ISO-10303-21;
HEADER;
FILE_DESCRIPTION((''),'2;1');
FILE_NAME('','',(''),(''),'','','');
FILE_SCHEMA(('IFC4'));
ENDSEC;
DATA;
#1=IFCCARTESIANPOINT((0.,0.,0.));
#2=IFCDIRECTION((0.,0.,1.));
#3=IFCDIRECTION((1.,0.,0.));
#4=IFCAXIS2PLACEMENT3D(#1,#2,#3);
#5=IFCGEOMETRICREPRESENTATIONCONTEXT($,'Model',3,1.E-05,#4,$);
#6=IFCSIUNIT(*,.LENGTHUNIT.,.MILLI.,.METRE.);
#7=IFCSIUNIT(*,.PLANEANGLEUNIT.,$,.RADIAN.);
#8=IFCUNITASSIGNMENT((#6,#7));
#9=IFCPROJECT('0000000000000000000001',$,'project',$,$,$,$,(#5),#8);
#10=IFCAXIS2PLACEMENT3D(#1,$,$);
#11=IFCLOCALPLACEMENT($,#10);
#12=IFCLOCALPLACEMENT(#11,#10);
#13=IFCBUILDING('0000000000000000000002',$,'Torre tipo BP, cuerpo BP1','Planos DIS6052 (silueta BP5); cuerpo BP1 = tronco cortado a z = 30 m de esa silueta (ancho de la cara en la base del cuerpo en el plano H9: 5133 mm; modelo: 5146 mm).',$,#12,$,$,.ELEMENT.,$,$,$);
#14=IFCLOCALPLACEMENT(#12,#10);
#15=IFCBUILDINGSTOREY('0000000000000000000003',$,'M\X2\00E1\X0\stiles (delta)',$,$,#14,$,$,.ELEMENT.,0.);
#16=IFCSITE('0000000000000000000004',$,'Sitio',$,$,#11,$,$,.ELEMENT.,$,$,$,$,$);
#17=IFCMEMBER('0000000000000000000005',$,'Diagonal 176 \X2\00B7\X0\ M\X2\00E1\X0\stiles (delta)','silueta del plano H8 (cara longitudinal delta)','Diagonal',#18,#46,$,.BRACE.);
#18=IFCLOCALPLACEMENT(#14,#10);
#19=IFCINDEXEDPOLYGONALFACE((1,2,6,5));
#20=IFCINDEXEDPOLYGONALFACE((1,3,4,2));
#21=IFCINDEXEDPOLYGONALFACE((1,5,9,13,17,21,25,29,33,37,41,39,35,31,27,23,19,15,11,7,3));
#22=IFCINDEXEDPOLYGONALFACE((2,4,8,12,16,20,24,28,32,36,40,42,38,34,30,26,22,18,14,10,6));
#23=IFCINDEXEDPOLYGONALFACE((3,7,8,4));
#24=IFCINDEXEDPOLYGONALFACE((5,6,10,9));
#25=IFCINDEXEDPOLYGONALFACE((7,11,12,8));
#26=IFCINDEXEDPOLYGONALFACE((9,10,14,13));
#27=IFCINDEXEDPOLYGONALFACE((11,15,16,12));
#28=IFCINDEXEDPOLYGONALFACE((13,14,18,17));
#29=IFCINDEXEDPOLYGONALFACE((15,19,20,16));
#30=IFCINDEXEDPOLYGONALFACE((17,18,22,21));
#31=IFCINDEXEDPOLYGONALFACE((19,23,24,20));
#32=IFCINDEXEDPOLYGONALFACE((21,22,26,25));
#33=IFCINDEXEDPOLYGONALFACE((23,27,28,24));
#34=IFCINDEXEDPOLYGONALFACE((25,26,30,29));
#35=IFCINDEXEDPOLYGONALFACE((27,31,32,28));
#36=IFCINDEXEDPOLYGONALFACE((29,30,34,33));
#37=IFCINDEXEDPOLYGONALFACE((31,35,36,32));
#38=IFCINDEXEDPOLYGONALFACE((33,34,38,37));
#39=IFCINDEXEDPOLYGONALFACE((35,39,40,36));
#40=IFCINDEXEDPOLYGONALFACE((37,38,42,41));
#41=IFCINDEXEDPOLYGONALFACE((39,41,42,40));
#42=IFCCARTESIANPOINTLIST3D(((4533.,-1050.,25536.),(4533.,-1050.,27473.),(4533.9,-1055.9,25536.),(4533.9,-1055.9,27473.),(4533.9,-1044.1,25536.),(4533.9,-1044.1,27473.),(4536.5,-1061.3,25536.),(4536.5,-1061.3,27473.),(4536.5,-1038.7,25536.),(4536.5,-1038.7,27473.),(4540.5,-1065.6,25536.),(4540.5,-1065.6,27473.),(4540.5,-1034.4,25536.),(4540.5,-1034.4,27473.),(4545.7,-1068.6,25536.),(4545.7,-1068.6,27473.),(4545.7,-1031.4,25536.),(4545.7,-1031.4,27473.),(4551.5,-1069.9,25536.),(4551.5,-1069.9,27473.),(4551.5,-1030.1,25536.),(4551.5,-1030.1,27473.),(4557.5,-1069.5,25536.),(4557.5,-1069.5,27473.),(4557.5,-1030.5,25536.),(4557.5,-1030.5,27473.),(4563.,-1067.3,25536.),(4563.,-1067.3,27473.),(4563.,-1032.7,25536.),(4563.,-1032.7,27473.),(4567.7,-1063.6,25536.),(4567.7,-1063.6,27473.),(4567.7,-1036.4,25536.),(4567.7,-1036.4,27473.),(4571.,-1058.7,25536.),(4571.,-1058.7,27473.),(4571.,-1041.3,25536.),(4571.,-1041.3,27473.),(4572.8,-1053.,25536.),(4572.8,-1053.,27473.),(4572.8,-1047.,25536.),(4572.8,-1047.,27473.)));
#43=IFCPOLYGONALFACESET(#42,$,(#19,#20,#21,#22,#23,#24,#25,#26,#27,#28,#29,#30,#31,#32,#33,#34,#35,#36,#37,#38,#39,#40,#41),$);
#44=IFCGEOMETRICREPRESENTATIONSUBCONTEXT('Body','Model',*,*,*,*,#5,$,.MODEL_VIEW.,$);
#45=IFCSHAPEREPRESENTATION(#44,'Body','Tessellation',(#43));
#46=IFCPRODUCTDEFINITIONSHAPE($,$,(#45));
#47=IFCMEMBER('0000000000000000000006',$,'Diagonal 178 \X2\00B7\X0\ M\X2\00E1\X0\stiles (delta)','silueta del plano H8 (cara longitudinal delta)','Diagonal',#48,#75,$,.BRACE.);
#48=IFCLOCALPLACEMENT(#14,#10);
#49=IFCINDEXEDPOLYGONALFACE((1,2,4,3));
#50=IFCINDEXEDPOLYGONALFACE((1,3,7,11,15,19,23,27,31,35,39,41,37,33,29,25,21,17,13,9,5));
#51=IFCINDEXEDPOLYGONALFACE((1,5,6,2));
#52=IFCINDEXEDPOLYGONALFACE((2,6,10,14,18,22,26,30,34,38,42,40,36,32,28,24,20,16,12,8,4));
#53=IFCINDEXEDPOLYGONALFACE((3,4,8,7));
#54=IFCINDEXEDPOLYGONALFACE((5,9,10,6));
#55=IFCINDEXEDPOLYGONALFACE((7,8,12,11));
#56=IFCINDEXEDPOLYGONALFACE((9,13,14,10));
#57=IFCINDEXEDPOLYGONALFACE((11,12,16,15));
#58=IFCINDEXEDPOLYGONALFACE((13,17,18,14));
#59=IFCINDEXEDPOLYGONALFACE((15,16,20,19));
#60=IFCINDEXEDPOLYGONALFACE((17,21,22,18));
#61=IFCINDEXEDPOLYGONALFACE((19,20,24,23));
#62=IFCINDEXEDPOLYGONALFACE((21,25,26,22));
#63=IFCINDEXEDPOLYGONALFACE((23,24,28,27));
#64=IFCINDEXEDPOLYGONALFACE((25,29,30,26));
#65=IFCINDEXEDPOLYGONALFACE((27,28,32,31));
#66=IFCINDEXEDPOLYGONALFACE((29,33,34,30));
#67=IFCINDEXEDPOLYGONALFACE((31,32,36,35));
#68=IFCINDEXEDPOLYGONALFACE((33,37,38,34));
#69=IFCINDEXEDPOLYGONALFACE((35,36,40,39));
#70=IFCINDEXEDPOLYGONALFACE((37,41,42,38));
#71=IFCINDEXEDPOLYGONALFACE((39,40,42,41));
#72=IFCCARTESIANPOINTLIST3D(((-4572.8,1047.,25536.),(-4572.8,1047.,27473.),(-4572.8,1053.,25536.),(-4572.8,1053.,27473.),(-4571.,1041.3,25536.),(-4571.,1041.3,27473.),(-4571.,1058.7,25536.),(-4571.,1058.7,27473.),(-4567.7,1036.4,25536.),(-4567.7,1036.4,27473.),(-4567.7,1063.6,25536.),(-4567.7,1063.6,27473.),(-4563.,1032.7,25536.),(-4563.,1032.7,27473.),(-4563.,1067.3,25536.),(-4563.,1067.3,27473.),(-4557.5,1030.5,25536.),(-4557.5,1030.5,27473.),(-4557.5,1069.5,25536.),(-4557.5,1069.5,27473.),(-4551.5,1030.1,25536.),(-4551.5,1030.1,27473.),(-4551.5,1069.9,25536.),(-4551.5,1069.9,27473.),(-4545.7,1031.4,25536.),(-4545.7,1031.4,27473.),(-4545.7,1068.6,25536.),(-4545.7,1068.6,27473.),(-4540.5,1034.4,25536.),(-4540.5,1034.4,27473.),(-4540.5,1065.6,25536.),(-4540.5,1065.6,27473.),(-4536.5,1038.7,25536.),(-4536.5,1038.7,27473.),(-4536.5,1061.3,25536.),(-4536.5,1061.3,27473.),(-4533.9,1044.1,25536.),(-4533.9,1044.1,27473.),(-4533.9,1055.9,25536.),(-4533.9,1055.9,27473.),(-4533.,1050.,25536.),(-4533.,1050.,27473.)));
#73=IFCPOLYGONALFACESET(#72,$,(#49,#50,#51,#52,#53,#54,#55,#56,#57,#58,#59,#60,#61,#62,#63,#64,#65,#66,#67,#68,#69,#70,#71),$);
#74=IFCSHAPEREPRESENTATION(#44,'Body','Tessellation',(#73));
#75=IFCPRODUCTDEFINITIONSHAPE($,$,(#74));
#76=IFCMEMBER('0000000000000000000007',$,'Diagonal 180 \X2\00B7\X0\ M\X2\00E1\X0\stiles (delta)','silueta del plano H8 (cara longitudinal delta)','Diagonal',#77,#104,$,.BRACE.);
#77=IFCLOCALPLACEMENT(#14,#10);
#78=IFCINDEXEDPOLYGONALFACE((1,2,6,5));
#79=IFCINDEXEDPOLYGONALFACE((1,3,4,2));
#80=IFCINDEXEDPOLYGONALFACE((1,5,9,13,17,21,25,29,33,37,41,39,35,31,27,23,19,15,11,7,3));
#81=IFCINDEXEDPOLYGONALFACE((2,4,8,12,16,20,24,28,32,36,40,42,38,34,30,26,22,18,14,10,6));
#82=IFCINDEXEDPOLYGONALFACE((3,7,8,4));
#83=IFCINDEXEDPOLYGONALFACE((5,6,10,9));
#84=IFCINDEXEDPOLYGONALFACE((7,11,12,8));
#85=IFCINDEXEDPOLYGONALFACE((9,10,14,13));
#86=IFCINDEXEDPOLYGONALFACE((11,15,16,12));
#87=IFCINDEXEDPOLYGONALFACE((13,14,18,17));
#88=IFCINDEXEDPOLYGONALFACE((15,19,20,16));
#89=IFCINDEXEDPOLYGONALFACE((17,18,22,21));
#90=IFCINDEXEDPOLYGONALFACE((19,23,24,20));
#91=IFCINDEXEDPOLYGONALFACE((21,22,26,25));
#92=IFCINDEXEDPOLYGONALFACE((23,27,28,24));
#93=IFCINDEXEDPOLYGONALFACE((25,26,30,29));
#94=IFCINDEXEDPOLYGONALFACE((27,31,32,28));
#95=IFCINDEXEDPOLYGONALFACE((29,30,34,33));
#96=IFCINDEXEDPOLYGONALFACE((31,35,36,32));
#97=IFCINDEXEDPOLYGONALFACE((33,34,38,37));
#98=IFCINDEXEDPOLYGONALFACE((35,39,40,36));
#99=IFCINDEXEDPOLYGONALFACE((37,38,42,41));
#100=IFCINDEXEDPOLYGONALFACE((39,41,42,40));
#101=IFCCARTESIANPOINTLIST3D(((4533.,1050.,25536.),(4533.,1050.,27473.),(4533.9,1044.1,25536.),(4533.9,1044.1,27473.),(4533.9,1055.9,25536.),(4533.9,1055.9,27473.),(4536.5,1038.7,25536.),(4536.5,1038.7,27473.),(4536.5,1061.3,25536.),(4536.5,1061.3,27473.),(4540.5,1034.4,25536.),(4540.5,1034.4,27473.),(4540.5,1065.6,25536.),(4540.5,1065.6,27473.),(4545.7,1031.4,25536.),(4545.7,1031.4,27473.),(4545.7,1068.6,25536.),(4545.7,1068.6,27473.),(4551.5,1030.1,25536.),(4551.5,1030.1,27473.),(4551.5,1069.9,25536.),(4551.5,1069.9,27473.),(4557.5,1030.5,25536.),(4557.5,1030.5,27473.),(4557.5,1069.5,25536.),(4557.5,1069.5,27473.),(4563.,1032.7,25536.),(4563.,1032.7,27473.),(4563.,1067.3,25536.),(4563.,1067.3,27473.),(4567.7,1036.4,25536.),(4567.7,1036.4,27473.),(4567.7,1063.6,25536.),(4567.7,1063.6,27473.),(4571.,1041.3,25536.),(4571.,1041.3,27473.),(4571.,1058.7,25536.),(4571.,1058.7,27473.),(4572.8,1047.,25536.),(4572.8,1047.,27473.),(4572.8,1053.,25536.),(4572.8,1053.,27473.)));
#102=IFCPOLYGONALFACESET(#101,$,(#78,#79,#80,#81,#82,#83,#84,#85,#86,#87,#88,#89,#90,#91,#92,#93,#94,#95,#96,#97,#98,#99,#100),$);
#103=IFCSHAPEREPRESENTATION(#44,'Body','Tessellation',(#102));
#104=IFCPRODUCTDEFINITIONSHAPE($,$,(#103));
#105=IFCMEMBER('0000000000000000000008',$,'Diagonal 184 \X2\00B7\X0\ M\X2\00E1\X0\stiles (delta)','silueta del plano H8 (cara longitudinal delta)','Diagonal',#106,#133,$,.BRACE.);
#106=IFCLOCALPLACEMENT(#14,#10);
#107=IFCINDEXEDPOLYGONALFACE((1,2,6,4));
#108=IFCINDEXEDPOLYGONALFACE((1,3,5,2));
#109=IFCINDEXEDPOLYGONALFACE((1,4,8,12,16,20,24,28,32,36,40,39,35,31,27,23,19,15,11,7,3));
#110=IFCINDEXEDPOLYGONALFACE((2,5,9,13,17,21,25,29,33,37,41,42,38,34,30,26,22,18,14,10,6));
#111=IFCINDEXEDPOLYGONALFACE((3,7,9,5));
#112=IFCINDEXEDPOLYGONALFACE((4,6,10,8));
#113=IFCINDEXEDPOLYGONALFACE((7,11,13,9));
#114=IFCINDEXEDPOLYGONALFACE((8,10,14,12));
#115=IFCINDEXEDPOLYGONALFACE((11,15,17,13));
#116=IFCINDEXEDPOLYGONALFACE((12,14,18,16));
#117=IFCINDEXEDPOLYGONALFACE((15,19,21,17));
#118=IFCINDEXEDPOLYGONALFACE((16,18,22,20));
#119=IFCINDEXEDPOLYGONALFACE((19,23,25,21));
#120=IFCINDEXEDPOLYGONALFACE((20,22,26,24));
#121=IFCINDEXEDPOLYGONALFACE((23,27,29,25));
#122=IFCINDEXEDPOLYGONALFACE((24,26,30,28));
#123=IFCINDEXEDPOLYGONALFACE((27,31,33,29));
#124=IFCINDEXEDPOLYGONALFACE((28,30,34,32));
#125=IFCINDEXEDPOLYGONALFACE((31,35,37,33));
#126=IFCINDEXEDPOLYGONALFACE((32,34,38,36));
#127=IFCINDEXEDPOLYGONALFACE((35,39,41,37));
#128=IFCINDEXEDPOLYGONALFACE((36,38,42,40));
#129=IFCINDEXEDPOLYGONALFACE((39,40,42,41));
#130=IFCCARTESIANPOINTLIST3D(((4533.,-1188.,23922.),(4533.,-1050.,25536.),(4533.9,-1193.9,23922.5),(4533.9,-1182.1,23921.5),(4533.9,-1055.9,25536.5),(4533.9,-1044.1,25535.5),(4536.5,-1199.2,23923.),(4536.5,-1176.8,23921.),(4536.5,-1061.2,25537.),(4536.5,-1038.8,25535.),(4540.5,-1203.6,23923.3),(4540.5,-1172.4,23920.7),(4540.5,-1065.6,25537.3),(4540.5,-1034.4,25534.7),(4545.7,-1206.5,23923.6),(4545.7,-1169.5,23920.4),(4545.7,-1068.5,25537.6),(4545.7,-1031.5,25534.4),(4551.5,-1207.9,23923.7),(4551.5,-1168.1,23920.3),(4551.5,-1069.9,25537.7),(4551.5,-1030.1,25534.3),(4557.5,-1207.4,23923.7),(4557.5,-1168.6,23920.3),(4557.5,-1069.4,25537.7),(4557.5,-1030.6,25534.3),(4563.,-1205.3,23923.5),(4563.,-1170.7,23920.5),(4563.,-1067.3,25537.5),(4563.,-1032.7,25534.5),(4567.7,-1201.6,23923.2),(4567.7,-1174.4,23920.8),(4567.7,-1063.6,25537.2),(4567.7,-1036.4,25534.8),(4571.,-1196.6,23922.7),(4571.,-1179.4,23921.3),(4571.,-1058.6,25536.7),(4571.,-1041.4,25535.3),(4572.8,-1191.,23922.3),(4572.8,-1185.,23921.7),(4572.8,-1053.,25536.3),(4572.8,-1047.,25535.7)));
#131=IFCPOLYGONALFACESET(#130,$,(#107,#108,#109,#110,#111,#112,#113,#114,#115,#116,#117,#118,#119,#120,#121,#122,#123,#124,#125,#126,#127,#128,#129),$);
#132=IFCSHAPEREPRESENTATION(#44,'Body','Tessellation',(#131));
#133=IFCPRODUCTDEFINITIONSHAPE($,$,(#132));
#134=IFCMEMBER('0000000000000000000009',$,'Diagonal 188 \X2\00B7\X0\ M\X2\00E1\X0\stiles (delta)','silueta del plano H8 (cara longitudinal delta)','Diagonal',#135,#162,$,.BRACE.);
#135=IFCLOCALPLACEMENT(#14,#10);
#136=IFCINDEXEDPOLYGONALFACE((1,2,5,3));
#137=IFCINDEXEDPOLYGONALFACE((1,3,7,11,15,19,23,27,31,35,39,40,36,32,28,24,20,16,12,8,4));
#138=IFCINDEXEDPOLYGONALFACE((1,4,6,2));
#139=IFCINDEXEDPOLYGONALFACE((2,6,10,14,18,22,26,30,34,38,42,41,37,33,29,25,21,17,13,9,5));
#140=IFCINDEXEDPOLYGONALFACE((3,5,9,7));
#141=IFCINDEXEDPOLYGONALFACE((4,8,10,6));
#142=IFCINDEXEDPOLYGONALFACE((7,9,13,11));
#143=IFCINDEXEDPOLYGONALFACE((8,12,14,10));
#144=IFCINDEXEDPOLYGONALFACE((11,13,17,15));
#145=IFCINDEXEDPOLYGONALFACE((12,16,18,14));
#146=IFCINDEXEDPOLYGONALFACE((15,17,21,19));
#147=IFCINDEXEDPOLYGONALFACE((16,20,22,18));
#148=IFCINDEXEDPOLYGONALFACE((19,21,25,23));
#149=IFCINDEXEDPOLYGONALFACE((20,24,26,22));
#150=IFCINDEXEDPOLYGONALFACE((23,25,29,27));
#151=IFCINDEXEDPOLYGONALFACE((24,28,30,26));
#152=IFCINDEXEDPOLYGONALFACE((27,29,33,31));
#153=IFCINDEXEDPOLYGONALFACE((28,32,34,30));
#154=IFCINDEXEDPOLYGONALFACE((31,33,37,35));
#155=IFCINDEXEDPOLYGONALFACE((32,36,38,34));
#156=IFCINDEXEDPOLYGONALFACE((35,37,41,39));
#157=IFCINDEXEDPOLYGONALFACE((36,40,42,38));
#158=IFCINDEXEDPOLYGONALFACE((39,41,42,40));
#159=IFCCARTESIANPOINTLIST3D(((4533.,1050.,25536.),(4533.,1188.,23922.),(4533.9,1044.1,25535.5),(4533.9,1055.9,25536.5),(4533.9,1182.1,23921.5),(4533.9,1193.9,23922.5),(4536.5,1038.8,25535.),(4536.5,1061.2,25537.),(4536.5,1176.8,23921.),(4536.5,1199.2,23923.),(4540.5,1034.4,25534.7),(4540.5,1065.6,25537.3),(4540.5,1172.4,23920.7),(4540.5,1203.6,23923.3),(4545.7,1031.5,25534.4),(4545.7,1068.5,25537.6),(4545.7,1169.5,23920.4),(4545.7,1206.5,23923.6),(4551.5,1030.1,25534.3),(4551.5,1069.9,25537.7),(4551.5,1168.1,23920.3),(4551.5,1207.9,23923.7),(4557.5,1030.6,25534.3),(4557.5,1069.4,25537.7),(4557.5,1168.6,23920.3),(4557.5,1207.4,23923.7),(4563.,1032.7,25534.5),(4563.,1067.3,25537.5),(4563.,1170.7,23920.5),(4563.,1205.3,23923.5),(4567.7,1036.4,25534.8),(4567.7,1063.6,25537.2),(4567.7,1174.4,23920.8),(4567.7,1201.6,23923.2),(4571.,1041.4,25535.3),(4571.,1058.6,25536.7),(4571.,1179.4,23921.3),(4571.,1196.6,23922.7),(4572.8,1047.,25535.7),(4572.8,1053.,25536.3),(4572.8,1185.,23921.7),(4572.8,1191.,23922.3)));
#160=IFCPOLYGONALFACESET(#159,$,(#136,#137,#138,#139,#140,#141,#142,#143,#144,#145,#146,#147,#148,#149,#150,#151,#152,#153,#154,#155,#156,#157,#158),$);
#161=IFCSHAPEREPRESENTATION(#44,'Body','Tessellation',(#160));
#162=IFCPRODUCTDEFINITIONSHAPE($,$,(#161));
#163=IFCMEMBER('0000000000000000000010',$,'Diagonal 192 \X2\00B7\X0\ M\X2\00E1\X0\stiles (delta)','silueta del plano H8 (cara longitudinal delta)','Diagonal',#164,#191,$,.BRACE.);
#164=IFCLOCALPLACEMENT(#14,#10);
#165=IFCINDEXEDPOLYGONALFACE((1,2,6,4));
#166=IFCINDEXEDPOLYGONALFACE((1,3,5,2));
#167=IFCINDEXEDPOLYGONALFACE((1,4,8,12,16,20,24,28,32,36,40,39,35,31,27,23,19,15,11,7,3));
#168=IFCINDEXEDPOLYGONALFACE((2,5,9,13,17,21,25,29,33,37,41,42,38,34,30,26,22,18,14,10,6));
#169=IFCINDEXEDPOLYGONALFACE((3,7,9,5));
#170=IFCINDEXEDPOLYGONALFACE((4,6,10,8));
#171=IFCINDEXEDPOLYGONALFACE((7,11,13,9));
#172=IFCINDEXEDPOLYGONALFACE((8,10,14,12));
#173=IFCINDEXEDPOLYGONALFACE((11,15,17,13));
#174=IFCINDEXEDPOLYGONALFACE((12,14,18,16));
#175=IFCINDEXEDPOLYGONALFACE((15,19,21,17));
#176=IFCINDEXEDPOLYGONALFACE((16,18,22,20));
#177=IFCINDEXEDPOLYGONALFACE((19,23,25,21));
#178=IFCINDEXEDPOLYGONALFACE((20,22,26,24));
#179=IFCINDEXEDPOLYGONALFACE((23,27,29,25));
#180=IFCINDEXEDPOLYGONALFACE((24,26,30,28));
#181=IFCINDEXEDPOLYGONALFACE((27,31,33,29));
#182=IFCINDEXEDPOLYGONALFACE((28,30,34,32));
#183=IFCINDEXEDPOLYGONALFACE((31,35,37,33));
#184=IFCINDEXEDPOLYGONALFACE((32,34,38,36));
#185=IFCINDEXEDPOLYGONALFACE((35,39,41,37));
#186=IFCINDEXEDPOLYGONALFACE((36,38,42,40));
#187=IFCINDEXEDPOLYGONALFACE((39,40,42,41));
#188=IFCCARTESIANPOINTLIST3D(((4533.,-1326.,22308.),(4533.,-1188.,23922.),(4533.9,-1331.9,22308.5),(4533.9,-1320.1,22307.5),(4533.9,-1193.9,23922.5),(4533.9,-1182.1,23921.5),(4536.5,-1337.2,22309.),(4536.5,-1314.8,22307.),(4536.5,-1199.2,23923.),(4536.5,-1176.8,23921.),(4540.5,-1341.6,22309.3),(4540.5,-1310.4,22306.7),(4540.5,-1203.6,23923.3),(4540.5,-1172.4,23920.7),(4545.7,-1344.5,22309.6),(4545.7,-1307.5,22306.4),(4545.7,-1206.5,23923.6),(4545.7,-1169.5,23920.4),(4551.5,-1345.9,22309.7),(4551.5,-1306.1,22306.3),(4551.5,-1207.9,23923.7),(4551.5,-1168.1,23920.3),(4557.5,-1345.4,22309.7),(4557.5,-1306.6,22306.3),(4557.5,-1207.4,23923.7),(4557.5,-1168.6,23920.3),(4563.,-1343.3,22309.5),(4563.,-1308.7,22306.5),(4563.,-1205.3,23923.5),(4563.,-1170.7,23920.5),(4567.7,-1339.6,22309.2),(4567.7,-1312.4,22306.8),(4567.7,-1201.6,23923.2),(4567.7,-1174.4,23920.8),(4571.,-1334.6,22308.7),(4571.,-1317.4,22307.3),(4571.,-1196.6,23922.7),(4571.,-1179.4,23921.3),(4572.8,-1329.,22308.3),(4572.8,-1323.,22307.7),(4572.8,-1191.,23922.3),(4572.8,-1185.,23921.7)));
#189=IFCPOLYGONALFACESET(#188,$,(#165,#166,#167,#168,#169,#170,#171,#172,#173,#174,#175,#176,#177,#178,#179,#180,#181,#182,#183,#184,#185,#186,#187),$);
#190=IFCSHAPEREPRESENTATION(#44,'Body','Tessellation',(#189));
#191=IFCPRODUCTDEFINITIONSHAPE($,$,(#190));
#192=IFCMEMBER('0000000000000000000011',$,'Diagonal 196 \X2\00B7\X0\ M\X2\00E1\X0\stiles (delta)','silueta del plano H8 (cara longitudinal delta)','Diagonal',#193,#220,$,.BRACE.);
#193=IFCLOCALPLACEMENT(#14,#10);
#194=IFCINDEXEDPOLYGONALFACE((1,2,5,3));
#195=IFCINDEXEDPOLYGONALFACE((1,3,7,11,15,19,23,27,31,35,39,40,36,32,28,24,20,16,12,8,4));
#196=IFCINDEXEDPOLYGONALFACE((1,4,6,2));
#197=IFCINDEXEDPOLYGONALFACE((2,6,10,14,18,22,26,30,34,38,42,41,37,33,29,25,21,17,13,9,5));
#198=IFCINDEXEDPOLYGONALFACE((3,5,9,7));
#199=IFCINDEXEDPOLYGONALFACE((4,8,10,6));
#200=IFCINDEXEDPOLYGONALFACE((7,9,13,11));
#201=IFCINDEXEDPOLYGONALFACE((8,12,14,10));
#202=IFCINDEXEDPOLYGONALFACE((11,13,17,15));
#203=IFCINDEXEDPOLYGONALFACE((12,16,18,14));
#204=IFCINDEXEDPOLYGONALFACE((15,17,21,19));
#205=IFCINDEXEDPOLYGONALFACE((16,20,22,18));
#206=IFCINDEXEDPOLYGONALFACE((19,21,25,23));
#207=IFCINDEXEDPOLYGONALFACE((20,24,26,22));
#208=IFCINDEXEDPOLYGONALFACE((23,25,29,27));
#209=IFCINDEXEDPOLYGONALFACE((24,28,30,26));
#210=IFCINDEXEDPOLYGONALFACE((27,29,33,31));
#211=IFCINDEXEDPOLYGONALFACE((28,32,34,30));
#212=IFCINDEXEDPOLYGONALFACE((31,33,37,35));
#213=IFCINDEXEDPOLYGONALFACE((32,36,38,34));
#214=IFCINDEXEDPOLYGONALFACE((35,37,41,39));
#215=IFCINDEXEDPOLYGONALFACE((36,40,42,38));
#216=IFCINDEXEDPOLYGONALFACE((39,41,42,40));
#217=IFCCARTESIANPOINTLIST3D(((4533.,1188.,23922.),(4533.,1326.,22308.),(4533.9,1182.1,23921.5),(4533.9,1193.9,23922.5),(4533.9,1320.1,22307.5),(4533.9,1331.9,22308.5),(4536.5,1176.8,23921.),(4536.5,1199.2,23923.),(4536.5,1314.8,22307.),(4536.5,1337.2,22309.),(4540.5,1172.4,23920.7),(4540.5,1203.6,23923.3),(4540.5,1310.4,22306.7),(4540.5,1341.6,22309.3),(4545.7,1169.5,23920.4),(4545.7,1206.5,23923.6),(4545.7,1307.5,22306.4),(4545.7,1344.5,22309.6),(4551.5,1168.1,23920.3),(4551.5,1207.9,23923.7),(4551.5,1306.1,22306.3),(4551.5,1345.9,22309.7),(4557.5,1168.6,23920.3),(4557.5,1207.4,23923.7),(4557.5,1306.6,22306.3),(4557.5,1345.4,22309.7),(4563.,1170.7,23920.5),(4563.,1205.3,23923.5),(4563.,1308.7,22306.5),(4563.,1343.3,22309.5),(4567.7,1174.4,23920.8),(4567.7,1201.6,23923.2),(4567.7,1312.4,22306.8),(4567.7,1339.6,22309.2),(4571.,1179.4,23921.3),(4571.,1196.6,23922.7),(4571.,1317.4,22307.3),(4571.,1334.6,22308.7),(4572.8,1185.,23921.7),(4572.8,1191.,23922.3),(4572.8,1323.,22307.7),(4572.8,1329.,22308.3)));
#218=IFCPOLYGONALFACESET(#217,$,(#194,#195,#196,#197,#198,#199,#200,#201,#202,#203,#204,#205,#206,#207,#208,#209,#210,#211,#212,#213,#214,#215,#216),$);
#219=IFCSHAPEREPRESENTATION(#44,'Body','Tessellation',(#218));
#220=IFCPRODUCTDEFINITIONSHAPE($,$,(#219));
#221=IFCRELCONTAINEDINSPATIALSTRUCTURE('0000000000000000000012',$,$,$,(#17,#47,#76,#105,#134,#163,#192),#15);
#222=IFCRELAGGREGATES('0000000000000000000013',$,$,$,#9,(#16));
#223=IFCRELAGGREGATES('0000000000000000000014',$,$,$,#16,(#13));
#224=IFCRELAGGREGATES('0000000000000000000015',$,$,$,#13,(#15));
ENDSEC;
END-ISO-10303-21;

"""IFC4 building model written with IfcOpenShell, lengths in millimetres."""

from ifc_helpers import new_model, si_unit, frame, origin, origin_with_axes, place, context, subcontext, project, spatial, circle, extrude, element, save


model = new_model("IFC4")

# Units and contexts
model_context = context("Model", 3, precision=1e-05, world=origin_with_axes())
body_context = subcontext(model_context, "Body", "Model", "MODEL_VIEW")
ifc_project = project(units=[si_unit("LENGTHUNIT", "METRE", prefix="MILLI"), si_unit("PLANEANGLEUNIT", "RADIAN")], contexts=[model_context])

# Site, building, storey
site_placement = place(None, origin())
site = spatial("IfcSite", under=ifc_project, at=site_placement, Name="Sitio", CompositionType="ELEMENT")
building_placement = place(site_placement, origin())
building = spatial("IfcBuilding", under=site, at=building_placement, Name="Torre tipo BP, cuerpo BP1", Description="Planos DIS6052 (silueta BP5); cuerpo BP1 = tronco cortado a z = 30 m de esa silueta (ancho de la cara en la base del cuerpo en el plano H9: 5133 mm; modelo: 5146 mm).", CompositionType="ELEMENT")
storey_placement = place(building_placement, origin())
storey = spatial("IfcBuildingStorey", under=building, at=storey_placement, Name="Mástiles (delta)", CompositionType="ELEMENT", Elevation=0.0)

# Members
for number, where, z_axis, x_axis, name in (
    (1, (4553.0, -1050.0, 27473.0), (0.0, 0.0, -1.0), (-1.0, 0.0, 0.0), "Diagonal 176 · Mástiles (delta)"),
    (2, (-4553.0, 1050.0, 27473.0), (0.0, 0.0, -1.0), (1.0, 0.0, 0.0), "Diagonal 178 · Mástiles (delta)"),
    (3, (4553.0, 1050.0, 27473.0), (0.0, 0.0, -1.0), (-1.0, 0.0, 0.0), "Diagonal 180 · Mástiles (delta)"),
):
    element("IfcMember", number, at=place(storey_placement, frame(where, z_axis=z_axis, x_axis=x_axis)), inside=storey, Name=name, Description="silueta del plano H8 (cara longitudinal delta)", ObjectType="Diagonal", PredefinedType="BRACE", context=body_context, shape_type="SweptSolid", body=[
        extrude(circle(Radius=20.0), None, (0.0, 0.0, 1.0), 1937.0),
    ])
for number, where, z_axis, x_axis, name in (
    (4, (4553.0, -1050.0, 25536.0), (0.0, -0.085191, -0.996365), (-1.0, 0.0, 0.0), "Diagonal 184 · Mástiles (delta)"),
    (5, (4553.0, 1050.0, 25536.0), (0.0, 0.085191, -0.996365), (-1.0, 0.0, 0.0), "Diagonal 188 · Mástiles (delta)"),
    (6, (4553.0, -1188.0, 23922.0), (0.0, -0.085191, -0.996365), (-1.0, 0.0, 0.0), "Diagonal 192 · Mástiles (delta)"),
    (7, (4553.0, 1188.0, 23922.0), (0.0, 0.085191, -0.996365), (-1.0, 0.0, 0.0), "Diagonal 196 · Mástiles (delta)"),
):
    element("IfcMember", number, at=place(storey_placement, frame(where, z_axis=z_axis, x_axis=x_axis)), inside=storey, Name=name, Description="silueta del plano H8 (cara longitudinal delta)", ObjectType="Diagonal", PredefinedType="BRACE", context=body_context, shape_type="SweptSolid", body=[
        extrude(circle(Radius=20.0), None, (0.0, 0.0, 1.0), 1619.9),
    ])

save(model, "model.ifc")
